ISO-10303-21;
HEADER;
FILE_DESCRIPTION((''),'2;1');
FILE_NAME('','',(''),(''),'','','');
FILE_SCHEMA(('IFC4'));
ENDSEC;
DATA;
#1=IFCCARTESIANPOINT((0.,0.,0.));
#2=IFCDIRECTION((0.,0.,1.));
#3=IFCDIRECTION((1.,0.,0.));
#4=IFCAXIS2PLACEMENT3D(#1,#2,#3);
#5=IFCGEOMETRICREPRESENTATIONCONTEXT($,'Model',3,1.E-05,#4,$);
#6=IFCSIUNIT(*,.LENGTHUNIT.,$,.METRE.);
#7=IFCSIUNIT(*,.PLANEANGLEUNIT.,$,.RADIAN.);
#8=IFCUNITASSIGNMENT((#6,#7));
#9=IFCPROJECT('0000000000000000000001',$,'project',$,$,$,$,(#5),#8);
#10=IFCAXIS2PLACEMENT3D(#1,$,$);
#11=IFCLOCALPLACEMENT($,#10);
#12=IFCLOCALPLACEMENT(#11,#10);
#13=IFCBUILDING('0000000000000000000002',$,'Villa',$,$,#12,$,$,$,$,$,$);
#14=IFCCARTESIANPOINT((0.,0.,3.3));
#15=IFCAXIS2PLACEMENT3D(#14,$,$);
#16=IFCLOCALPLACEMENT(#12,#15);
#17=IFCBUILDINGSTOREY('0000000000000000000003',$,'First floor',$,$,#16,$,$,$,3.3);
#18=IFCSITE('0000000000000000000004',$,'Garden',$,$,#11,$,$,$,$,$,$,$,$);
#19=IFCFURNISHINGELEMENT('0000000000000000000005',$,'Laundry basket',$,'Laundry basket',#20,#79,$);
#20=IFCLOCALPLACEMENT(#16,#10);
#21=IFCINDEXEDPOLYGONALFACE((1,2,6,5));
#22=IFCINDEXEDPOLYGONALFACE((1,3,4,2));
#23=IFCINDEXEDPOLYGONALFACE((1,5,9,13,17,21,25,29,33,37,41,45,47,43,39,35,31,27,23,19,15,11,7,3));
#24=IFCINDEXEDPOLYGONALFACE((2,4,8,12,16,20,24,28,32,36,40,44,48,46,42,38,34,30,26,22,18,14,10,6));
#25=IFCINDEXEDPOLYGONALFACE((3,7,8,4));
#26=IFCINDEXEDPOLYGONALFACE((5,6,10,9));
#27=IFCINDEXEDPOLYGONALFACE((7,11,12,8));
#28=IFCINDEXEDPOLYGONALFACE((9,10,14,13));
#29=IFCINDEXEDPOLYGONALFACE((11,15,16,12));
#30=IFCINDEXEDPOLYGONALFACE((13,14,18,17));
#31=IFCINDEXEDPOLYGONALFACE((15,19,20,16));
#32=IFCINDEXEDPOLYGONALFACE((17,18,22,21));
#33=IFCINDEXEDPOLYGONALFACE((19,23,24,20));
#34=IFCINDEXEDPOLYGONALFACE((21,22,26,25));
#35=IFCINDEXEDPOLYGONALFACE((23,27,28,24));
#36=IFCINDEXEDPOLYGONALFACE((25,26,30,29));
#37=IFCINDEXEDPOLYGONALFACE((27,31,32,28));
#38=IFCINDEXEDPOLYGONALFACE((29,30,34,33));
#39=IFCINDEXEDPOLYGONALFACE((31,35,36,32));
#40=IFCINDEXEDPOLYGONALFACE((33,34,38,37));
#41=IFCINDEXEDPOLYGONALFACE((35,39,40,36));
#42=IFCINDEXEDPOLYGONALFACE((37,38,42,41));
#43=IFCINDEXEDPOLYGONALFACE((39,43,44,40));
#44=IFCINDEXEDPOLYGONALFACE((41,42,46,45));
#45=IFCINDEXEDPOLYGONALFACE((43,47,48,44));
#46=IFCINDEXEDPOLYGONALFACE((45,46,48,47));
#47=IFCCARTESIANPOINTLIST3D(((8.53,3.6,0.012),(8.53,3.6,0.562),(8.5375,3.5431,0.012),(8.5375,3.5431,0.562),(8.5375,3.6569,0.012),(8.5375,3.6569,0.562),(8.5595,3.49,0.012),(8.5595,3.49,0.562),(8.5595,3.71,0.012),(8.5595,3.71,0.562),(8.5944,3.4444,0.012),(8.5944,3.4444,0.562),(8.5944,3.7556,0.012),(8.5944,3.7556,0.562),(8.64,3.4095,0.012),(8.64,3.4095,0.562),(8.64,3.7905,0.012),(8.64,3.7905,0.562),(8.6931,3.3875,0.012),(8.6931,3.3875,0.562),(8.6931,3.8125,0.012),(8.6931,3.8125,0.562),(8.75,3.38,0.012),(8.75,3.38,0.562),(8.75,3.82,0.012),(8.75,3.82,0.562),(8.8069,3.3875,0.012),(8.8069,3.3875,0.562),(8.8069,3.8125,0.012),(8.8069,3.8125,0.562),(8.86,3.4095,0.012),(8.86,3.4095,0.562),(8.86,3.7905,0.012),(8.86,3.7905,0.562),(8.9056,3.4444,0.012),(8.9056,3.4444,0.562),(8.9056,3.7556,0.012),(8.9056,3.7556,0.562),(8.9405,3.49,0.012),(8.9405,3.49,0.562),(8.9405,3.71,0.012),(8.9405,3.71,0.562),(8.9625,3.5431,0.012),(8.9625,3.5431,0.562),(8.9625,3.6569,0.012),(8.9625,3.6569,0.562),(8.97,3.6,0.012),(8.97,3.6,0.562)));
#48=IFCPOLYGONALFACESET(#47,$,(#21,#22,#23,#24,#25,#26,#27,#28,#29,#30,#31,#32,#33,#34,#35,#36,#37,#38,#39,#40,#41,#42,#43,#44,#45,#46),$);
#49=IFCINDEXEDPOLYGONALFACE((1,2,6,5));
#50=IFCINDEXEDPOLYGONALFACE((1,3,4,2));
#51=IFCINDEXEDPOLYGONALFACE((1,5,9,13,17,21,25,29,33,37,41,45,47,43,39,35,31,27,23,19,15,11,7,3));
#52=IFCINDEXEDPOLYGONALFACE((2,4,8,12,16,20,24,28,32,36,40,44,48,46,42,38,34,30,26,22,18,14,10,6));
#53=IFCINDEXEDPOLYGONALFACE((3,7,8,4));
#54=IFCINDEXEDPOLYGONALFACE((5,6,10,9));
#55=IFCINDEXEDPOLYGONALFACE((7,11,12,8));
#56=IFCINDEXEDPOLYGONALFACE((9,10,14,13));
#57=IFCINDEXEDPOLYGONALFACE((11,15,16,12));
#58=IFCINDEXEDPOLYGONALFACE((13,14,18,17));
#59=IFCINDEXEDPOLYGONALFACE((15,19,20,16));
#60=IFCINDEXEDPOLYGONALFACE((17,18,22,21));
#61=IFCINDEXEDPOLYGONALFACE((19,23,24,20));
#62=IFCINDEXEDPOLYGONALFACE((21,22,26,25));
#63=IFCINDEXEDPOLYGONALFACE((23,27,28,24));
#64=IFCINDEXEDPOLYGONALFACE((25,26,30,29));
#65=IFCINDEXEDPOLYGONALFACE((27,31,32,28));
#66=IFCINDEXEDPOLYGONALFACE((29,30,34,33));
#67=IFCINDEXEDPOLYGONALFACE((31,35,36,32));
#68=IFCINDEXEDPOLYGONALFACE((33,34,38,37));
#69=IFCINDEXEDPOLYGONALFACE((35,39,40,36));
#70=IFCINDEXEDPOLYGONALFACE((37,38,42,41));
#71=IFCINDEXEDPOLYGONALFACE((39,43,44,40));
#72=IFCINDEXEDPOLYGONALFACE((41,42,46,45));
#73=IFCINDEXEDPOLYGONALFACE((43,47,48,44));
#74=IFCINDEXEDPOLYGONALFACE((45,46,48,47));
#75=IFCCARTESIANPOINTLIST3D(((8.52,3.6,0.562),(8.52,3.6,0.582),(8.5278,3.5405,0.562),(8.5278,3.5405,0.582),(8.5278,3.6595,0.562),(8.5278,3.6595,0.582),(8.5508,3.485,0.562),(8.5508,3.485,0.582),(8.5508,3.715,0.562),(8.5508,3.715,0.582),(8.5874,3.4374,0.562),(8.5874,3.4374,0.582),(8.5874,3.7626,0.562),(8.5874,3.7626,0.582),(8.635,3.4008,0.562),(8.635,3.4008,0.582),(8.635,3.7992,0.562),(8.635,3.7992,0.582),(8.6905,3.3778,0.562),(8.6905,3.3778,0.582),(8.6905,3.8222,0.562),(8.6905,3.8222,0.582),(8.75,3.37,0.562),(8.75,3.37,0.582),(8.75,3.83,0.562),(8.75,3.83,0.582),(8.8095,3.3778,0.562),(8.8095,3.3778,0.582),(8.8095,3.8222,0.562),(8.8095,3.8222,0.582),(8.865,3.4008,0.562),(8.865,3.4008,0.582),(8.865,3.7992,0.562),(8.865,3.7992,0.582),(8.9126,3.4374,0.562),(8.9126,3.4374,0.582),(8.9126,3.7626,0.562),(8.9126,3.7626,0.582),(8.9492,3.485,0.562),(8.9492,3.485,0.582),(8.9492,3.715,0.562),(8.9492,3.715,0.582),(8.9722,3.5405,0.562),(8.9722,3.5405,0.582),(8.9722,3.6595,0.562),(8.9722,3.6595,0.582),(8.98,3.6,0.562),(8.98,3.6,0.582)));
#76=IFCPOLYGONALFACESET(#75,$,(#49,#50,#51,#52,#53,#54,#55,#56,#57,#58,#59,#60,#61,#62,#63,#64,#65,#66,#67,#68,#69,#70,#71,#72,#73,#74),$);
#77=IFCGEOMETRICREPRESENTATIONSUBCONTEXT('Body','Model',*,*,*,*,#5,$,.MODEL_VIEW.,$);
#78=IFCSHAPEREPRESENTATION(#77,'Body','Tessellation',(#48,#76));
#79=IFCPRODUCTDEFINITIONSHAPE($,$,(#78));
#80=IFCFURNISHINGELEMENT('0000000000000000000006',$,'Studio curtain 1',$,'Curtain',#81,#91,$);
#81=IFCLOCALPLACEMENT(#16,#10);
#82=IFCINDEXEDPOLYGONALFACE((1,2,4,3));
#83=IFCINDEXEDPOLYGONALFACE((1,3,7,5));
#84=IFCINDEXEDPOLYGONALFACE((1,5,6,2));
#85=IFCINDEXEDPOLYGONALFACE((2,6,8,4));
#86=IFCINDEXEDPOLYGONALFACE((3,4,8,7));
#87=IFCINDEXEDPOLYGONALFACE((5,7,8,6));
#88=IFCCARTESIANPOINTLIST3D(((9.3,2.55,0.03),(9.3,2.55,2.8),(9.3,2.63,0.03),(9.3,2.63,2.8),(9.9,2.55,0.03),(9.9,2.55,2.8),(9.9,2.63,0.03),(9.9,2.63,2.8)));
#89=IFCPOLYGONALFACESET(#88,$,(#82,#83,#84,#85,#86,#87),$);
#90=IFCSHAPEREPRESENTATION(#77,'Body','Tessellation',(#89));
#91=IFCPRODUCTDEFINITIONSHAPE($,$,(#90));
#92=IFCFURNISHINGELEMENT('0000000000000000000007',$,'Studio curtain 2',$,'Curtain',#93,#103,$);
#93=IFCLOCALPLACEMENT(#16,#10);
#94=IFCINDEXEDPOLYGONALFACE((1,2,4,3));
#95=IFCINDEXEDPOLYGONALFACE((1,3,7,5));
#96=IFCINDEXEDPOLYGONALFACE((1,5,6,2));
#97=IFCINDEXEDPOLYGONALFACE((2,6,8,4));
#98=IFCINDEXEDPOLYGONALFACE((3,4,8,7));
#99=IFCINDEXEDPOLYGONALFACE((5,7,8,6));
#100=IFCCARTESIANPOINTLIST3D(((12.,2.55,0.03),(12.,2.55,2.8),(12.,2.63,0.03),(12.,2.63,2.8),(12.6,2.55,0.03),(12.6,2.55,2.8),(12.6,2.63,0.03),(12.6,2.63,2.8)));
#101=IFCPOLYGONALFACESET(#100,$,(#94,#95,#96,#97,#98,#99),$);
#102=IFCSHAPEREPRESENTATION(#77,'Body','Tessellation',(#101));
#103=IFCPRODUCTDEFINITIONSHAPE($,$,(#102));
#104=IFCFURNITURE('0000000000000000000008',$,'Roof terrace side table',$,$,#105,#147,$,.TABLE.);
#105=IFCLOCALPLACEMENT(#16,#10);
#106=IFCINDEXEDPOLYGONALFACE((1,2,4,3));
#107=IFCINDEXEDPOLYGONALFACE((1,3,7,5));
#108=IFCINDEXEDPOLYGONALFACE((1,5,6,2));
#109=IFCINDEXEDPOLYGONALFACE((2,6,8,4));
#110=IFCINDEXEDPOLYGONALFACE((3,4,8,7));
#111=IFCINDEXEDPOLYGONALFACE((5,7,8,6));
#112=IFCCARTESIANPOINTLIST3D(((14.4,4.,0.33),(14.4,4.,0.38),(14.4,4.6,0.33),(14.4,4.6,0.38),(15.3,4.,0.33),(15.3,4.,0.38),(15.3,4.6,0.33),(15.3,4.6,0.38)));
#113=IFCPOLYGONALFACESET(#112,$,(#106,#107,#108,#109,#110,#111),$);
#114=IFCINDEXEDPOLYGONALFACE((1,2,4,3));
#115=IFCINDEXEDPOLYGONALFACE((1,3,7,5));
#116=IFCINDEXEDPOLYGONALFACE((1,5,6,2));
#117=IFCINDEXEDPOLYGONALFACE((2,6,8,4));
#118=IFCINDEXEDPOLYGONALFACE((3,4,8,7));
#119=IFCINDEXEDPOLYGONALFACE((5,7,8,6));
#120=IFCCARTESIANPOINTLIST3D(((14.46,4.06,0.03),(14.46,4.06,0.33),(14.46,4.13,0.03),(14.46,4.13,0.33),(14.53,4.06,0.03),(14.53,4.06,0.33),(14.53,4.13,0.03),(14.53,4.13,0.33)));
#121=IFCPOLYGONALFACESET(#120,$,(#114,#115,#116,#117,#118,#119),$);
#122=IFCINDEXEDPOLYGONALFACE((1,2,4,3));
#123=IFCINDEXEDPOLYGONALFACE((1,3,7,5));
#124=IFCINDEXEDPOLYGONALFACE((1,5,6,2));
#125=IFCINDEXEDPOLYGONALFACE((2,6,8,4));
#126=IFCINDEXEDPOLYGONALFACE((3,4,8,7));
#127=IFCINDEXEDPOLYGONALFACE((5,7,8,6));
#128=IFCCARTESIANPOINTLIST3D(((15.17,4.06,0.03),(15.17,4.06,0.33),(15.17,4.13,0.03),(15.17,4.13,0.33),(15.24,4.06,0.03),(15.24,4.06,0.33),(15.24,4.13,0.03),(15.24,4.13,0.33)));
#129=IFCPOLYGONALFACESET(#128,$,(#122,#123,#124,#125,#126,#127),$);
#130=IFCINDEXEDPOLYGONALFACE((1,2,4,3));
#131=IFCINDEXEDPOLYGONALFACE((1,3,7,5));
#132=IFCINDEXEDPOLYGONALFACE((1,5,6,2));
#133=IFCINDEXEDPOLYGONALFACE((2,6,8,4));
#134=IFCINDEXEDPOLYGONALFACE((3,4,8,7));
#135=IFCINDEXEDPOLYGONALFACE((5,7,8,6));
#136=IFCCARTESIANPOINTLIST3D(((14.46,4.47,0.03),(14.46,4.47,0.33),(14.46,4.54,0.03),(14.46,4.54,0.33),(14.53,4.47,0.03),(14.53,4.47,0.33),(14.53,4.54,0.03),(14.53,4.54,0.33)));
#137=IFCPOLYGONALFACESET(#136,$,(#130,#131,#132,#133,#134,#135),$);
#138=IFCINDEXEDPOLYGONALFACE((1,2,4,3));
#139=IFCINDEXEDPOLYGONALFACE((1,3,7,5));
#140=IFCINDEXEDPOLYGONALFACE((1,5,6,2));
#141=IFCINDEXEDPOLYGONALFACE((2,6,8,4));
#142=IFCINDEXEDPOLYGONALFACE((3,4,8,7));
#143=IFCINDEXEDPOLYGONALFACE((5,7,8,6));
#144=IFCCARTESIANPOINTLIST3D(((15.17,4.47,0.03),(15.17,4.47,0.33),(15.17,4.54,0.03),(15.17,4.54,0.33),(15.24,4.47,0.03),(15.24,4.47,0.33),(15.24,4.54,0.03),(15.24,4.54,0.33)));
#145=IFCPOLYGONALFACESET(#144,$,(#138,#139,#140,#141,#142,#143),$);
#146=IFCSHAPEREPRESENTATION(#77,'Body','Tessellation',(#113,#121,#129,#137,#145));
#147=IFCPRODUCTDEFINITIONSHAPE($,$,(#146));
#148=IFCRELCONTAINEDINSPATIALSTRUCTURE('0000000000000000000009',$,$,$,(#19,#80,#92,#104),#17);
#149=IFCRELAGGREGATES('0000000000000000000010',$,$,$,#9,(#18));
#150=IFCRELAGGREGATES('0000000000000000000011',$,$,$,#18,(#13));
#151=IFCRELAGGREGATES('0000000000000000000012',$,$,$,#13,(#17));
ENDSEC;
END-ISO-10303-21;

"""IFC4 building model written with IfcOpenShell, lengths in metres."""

from ifc_helpers import new_model, si_unit, frame, frame_2d, origin, origin_with_axes, origin_2d, place, context, subcontext, project, spatial, rectangle, circle, extrude, element, save


model = new_model("IFC4")

# Units and contexts
model_context = context("Model", 3, precision=1e-05, world=origin_with_axes())
body_context = subcontext(model_context, "Body", "Model", "MODEL_VIEW")
ifc_project = project(units=[si_unit("LENGTHUNIT", "METRE"), si_unit("PLANEANGLEUNIT", "RADIAN")], contexts=[model_context])

# Site, building, storey
site_placement = place(None, origin())
site = spatial("IfcSite", under=ifc_project, at=site_placement, Name="Garden")
building_placement = place(site_placement, origin())
building = spatial("IfcBuilding", under=site, at=building_placement, Name="Villa")
storey_placement = place(building_placement, frame((0.0, 0.0, 3.3)))
storey = spatial("IfcBuildingStorey", under=building, at=storey_placement, Name="First floor", Elevation=3.3)

# Furnishing elements
furnishing_1_placement = place(storey_placement, frame((8.75, 3.6, 0.012)))
element("IfcFurnishingElement", 1, at=furnishing_1_placement, inside=storey, Name="Laundry basket", ObjectType="Laundry basket", context=body_context, shape_type="SweptSolid", body=[
    extrude(circle(Radius=0.22, at=origin_2d()), origin(), (0.0, 0.0, 1.0), 0.55),
    extrude(circle(Radius=0.23, at=origin_2d()), frame((0.0, 0.0, 0.55)), (0.0, 0.0, 1.0), 0.02),
])
furnishing_2_placement = place(storey_placement, origin())
element("IfcFurnishingElement", 2, at=furnishing_2_placement, inside=storey, Name="Studio curtain 1", ObjectType="Curtain", context=body_context, shape_type="SweptSolid", body=[
    extrude(rectangle(XDim=0.6, YDim=0.08, at=frame_2d((0.3, 0.04))), frame((9.3, 2.55, 0.03)), (0.0, 0.0, 1.0), 2.77),
])
furnishing_3_placement = place(storey_placement, origin())
element("IfcFurnishingElement", 3, at=furnishing_3_placement, inside=storey, Name="Studio curtain 2", ObjectType="Curtain", context=body_context, shape_type="SweptSolid", body=[
    extrude(rectangle(XDim=0.6, YDim=0.08, at=frame_2d((0.3, 0.04))), frame((12.0, 2.55, 0.03)), (0.0, 0.0, 1.0), 2.77),
])

# Furniture
furniture_1_placement = place(storey_placement, frame((14.4, 4.0, 0.03)))
element("IfcFurniture", 4, at=furniture_1_placement, inside=storey, Name="Roof terrace side table", PredefinedType="TABLE", context=body_context, shape_type="SweptSolid", body=[
    extrude(rectangle(XDim=0.9, YDim=0.6, at=frame_2d((0.45, 0.3))), frame((0.0, 0.0, 0.3)), (0.0, 0.0, 1.0), 0.05),
    extrude(rectangle(XDim=0.07, YDim=0.07, at=frame_2d((0.035, 0.035))), frame((0.06, 0.06, 0.0)), (0.0, 0.0, 1.0), 0.3),
    extrude(rectangle(XDim=0.07, YDim=0.07, at=frame_2d((0.035, 0.035))), frame((0.77, 0.06, 0.0)), (0.0, 0.0, 1.0), 0.3),
    extrude(rectangle(XDim=0.07, YDim=0.07, at=frame_2d((0.035, 0.035))), frame((0.06, 0.47, 0.0)), (0.0, 0.0, 1.0), 0.3),
    extrude(rectangle(XDim=0.07, YDim=0.07, at=frame_2d((0.035, 0.035))), frame((0.77, 0.47, 0.0)), (0.0, 0.0, 1.0), 0.3),
])

save(model, "model.ifc")
